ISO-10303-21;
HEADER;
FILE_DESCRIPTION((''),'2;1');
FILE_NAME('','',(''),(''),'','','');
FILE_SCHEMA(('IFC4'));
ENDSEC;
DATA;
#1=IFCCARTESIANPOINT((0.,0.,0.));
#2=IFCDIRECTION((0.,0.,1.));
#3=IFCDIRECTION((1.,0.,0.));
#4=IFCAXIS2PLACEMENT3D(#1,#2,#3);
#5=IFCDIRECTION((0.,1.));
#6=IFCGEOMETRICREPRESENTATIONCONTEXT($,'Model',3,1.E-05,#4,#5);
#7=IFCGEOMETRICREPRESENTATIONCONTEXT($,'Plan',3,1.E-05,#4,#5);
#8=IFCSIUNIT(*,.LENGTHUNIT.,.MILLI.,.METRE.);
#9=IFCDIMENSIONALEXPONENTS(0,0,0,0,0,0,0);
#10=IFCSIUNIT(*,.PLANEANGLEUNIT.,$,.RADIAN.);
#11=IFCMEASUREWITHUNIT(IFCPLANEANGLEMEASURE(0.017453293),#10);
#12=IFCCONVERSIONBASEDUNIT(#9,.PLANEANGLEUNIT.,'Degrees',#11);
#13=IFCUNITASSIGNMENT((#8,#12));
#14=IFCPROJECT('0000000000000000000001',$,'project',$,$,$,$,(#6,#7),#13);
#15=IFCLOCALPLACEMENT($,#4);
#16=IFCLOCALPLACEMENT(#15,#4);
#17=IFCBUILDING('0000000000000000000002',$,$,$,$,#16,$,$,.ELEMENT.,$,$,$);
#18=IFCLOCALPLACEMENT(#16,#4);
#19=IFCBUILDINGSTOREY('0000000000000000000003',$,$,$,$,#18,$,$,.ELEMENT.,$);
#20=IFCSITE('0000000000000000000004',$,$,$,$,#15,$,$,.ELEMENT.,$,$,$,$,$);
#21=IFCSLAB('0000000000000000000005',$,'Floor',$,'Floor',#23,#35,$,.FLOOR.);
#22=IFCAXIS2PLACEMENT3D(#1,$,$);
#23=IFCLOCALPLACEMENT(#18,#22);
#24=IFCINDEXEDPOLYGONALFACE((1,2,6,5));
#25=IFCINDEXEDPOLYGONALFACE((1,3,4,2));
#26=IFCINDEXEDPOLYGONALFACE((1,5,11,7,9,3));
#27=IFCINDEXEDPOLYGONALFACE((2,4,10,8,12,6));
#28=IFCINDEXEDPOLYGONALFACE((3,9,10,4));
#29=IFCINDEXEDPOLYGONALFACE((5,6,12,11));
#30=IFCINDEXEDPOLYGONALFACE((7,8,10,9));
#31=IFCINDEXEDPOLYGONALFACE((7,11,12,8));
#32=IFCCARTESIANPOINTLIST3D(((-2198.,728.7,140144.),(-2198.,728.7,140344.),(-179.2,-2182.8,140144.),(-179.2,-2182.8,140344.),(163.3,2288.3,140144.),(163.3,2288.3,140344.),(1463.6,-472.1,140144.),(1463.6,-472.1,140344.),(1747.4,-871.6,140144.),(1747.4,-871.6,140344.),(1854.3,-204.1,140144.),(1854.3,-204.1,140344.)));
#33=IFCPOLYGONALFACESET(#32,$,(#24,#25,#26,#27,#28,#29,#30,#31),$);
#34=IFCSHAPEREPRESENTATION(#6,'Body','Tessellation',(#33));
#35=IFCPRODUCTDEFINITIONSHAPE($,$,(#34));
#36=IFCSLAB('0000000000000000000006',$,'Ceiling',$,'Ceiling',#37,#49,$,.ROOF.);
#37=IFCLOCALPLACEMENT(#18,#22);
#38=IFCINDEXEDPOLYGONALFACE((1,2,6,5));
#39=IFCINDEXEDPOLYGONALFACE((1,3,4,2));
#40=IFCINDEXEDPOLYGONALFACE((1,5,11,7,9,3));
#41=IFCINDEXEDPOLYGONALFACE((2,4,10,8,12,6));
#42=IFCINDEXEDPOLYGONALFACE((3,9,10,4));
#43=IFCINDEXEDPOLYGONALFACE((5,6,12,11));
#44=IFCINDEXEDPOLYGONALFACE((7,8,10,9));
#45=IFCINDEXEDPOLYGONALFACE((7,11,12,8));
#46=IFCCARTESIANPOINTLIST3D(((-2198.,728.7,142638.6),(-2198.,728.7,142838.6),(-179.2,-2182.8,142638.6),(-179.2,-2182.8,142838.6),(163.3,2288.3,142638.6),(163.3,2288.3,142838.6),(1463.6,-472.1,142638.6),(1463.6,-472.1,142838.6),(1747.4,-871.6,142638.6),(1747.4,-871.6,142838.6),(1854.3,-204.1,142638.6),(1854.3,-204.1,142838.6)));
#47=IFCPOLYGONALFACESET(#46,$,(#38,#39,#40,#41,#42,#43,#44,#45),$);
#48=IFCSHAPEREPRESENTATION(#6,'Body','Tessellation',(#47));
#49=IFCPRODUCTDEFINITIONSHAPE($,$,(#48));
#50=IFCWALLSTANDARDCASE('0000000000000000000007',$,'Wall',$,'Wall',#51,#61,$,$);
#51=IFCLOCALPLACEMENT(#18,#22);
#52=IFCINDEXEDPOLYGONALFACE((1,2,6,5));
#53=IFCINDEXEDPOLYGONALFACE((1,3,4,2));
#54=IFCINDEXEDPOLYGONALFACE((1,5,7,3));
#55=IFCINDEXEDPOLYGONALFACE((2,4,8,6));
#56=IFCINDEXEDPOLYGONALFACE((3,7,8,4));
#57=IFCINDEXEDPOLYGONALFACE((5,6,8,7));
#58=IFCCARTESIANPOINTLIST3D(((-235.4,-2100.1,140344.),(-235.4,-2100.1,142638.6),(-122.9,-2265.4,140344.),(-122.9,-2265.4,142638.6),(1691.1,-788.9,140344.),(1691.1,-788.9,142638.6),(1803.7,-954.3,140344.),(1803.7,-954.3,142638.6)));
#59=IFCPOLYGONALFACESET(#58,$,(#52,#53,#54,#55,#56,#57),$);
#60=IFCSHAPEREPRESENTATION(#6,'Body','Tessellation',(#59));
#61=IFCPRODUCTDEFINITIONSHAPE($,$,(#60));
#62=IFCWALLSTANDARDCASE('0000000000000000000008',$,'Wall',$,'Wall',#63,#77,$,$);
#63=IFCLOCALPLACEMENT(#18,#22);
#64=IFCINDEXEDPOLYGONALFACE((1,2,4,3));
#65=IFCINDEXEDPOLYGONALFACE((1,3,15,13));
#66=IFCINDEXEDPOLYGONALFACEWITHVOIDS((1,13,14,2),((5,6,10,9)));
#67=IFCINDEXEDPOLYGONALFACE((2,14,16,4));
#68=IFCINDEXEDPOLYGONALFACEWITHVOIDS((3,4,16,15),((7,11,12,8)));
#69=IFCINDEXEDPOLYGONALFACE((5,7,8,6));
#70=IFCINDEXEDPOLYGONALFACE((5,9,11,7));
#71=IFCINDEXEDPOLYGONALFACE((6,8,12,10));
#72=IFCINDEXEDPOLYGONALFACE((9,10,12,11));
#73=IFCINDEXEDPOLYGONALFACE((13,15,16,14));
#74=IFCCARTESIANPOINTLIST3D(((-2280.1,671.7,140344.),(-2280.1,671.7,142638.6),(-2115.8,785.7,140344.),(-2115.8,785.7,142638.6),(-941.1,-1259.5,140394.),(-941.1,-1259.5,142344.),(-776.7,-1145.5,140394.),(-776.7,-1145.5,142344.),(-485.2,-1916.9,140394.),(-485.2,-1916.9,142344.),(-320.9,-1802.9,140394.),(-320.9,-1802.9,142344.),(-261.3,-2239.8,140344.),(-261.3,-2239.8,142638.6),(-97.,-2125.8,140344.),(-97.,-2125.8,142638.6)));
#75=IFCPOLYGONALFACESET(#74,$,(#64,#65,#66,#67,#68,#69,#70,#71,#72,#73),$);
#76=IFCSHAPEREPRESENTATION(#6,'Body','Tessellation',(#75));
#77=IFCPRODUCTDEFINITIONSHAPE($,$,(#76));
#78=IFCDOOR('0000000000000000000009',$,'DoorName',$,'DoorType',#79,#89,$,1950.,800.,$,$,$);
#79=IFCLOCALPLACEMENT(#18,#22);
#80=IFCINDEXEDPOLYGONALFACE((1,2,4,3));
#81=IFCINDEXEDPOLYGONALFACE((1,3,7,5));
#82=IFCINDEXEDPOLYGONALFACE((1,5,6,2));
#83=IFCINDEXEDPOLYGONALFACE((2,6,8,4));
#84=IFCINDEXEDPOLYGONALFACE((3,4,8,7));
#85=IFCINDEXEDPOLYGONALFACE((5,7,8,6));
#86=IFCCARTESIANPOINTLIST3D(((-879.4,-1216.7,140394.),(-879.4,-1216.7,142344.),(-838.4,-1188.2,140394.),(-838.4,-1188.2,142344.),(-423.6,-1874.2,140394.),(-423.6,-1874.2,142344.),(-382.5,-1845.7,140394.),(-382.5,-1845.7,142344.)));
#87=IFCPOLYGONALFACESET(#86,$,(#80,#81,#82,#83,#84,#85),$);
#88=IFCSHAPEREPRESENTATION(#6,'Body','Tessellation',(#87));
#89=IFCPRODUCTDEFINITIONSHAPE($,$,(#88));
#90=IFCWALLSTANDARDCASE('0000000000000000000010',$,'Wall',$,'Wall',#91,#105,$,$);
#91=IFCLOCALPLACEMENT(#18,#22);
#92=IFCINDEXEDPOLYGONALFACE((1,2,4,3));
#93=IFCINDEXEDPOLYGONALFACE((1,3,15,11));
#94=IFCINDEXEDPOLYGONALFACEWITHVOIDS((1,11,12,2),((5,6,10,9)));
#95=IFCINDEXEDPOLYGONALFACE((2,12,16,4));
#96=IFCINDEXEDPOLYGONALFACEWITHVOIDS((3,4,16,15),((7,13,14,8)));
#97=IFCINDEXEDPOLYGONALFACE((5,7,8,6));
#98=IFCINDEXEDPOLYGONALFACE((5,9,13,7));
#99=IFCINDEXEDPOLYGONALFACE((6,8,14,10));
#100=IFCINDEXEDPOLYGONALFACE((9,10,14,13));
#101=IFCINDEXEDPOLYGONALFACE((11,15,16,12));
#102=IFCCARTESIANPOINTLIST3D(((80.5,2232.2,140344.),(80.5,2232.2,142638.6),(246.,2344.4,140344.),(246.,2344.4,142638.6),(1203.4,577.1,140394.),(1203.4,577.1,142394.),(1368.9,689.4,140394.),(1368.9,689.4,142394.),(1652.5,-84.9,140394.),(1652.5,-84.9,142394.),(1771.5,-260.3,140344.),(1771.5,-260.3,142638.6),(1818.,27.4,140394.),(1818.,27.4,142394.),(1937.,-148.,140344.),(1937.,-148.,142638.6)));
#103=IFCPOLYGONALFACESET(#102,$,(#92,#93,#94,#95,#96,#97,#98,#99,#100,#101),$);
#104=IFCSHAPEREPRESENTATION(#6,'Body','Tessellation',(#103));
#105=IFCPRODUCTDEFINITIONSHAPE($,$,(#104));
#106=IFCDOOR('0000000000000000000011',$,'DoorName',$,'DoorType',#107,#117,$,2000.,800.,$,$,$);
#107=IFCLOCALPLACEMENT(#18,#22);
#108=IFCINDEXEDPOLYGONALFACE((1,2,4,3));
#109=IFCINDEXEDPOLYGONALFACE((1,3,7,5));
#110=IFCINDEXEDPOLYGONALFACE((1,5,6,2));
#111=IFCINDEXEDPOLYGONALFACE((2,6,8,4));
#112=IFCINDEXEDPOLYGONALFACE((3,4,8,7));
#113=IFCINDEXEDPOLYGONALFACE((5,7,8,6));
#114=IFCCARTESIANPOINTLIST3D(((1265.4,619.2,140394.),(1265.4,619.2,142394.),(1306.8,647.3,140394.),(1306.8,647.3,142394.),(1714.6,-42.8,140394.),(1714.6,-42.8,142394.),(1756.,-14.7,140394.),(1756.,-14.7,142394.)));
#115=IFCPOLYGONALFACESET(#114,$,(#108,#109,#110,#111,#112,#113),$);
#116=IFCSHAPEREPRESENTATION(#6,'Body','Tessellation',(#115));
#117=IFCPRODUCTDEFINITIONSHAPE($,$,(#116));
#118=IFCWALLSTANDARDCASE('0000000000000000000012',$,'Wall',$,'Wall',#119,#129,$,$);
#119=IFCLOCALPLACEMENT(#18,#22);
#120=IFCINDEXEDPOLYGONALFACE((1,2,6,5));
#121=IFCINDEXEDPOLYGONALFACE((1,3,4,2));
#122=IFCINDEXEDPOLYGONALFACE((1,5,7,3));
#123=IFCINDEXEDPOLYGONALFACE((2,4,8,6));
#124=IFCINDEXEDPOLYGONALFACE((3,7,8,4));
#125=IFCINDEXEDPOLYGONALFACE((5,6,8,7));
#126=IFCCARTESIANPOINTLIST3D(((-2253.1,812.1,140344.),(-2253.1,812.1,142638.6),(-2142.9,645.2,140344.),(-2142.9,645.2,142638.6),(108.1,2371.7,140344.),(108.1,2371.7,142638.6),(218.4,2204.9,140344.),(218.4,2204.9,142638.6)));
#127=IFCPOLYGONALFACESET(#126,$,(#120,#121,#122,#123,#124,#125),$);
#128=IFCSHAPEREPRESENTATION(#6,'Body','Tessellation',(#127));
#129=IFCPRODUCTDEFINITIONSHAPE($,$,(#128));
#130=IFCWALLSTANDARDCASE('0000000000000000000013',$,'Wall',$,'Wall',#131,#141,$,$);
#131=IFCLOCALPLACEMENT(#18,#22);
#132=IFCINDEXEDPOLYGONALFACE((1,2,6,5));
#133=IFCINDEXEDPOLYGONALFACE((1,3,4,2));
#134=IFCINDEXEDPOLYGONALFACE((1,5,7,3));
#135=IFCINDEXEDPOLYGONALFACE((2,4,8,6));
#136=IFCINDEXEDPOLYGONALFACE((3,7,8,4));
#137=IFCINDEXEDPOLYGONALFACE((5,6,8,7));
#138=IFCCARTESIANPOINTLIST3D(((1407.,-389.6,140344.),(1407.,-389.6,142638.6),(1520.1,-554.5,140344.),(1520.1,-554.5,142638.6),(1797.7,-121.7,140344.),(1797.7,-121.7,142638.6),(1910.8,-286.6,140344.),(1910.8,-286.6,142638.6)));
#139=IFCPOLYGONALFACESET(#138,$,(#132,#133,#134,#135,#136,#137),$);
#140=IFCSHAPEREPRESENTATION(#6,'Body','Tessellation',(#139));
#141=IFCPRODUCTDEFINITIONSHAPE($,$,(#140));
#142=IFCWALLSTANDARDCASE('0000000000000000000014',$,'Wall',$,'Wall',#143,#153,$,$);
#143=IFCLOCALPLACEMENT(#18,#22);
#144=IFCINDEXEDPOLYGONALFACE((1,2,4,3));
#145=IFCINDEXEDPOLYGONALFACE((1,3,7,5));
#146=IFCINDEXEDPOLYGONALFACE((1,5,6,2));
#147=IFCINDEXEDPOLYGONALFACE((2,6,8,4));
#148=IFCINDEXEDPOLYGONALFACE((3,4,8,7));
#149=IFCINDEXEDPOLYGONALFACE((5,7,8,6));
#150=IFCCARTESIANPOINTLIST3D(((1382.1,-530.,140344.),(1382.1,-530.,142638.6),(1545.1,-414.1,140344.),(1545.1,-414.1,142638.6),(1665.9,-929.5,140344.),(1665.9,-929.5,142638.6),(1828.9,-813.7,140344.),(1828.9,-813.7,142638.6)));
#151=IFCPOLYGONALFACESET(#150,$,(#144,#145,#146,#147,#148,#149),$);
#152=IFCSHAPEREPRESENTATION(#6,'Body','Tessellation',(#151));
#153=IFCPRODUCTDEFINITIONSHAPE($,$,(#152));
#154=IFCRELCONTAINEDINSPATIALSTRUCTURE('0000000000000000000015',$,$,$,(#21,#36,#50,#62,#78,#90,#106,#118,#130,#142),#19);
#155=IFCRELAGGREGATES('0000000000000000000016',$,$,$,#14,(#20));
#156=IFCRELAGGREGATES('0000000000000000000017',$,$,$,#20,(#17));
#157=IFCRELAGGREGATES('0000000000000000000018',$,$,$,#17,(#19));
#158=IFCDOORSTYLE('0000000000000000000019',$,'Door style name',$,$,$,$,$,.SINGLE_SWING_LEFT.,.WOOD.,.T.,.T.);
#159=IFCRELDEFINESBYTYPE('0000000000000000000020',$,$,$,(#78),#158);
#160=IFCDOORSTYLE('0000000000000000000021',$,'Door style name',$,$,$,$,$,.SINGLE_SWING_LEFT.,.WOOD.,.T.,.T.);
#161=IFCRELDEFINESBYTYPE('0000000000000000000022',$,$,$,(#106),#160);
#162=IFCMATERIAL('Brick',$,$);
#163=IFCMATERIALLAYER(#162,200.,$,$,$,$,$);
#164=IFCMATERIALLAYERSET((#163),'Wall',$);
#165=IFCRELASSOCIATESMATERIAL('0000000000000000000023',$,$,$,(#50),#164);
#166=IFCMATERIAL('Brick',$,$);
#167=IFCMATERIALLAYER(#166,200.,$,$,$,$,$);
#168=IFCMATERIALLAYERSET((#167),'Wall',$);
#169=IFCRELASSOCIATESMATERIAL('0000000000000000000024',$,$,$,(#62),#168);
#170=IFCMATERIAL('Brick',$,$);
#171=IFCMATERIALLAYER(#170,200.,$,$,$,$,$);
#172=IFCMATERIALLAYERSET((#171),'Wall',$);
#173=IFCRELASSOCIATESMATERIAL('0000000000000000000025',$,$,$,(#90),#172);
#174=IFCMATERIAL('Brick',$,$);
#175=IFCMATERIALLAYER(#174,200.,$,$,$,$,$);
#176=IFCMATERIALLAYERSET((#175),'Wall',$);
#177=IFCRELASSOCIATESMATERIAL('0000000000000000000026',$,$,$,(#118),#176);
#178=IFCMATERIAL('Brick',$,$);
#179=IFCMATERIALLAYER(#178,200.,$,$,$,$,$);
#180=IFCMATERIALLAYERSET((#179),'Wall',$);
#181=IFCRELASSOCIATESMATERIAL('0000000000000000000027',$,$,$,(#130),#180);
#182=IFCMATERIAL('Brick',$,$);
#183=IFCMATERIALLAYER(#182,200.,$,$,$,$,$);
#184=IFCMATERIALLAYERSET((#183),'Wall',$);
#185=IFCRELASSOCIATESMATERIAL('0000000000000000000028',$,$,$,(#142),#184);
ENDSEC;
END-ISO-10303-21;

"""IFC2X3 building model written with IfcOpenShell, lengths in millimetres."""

from ifc_helpers import new_model, entity, si_unit, converted_unit, direction, frame, origin_with_axes, place, context, project, spatial, polyline, outline, extrude, material, layer, layer_set, layer_usage, type_object, element, fill, save


model = new_model("IFC2X3")

# Units and contexts
model_context = context("Model", 3, precision=1e-05, world=origin_with_axes(), true_north=direction((0.0, 1.0)))
plan_context = context("Plan", 3, precision=1e-05, world=origin_with_axes(), true_north=direction((0.0, 1.0)))
ifc_project = project(units=[si_unit("LENGTHUNIT", "METRE", prefix="MILLI"), converted_unit("PLANEANGLEUNIT", "Degrees", entity("IfcPlaneAngleMeasure", 0.017453293), si_unit("PLANEANGLEUNIT", "RADIAN"), dimensions=[0, 0, 0, 0, 0, 0, 0])], contexts=[model_context, plan_context])

# Site, building, storey
site_placement = place(None, origin_with_axes())
site = spatial("IfcSite", under=ifc_project, at=site_placement, CompositionType="ELEMENT")
building_placement = place(site_placement, origin_with_axes())
building = spatial("IfcBuilding", under=site, at=building_placement, CompositionType="ELEMENT")
storey_placement = place(building_placement, origin_with_axes())
storey = spatial("IfcBuildingStorey", under=building, at=storey_placement, CompositionType="ELEMENT")

# Slabs
slab_1_placement = place(storey_placement, frame((0.0, 0.0, 140144.0), z_axis=(0.0, 0.0, 1.0), x_axis=(1.0, 0.0, 0.0)))
element("IfcSlab", 1, at=slab_1_placement, inside=storey, Name="Floor", ObjectType="Floor", PredefinedType="FLOOR", context=model_context, shape_type="SweptSolid", body=[
    extrude(outline(polyline([(1747.4, -871.6), (1463.6, -472.1), (1854.3, -204.1), (163.3, 2288.3), (-2198.0, 728.7), (-179.2, -2182.8), (1747.4, -871.6)])), origin_with_axes(), (0.0, 0.0, 1.0), 200.0),
])
slab_2_placement = place(storey_placement, frame((0.0, 0.0, 142638.6), z_axis=(0.0, 0.0, 1.0), x_axis=(1.0, 0.0, 0.0)))
element("IfcSlab", 2, at=slab_2_placement, inside=storey, Name="Ceiling", ObjectType="Ceiling", PredefinedType="ROOF", context=model_context, shape_type="SweptSolid", body=[
    extrude(outline(polyline([(1747.4, -871.6), (1463.6, -472.1), (1854.3, -204.1), (163.3, 2288.3), (-2198.0, 728.7), (-179.2, -2182.8), (1747.4, -871.6)])), origin_with_axes(), (0.0, 0.0, 1.0), 200.0),
])

# Wall
ifc_material_1 = material(Name="Brick")
ifc_layer_1 = layer(ifc_material_1, 200.0)
ifc_layer_set_1 = layer_set([ifc_layer_1], Name="Wall")
ifc_layer_usage_1 = layer_usage(ifc_layer_set_1, "AXIS2", "POSITIVE", -100.0)
wall_1_placement = place(storey_placement, frame((784.1, -1527.2, 140344.0), z_axis=(0.0, 0.0, 1.0), x_axis=(-0.826702, -0.56264, 0.0)))
element("IfcWallStandardCase", 3, at=wall_1_placement, inside=storey, material=ifc_layer_usage_1, Name="Wall", ObjectType="Wall", context=model_context, shape_type="SweptSolid", body=[
    extrude(outline(polyline([(-1165.2, -100.0), (1165.2, -100.0), (1165.2, 100.0), (-1165.2, 100.0), (-1165.2, -100.0)])), origin_with_axes(), (0.0, 0.0, 1.0), 2294.6),
])

# Walls, openings, doors
ifc_material_2 = material(Name="Brick")
ifc_layer_2 = layer(ifc_material_2, 200.0)
ifc_layer_set_2 = layer_set([ifc_layer_2], Name="Wall")
ifc_layer_usage_2 = layer_usage(ifc_layer_set_2, "AXIS2", "POSITIVE", -100.0)
wall_2_placement = place(storey_placement, frame((-1188.6, -727.1, 140344.0), z_axis=(0.0, 0.0, 1.0), x_axis=(0.569816, -0.821772, 0.0)))
wall_2 = element("IfcWallStandardCase", 4, at=wall_2_placement, inside=storey, material=ifc_layer_usage_2, Name="Wall", ObjectType="Wall", context=model_context, shape_type="SweptSolid", body=[
    extrude(outline(polyline([(-1771.4, -100.0), (1771.4, -100.0), (1771.4, 100.0), (-1771.4, 100.0), (-1771.4, -100.0)])), origin_with_axes(), (0.0, 0.0, 1.0), 2294.6),
])
placement_1 = place(storey_placement, frame((-631.0, -1531.2, 140394.0), z_axis=(0.0, 0.0, 1.0), x_axis=(0.569816, -0.821772, 0.0)))
opening_1 = element("IfcOpeningElement", 5, at=placement_1, cuts=wall_2, ObjectType="OpeningElement", context=model_context, shape_type="SweptSolid", body=[
    extrude(outline(polyline([(-400.0, -125.0), (400.0, -125.0), (400.0, 125.0), (-400.0, 125.0), (-400.0, -125.0)])), origin_with_axes(), (0.0, 0.0, 1.0), 1950.0),
])
door_style_1 = type_object("IfcDoorStyle", Name="Door style name", ConstructionType="WOOD", OperationType="SINGLE_SWING_LEFT", ParameterTakesPrecedence=True, Sizeable=True)
door_1 = element("IfcDoor", 6, at=placement_1, inside=storey, type_object=door_style_1, Name="DoorName", ObjectType="DoorType", OverallHeight=1950.0, OverallWidth=800.0, context=model_context, shape_type="SweptSolid", body=[
    extrude(outline(polyline([(-400.0, -25.0), (400.0, -25.0), (400.0, 25.0), (-400.0, 25.0), (-400.0, -25.0)])), origin_with_axes(), (0.0, 0.0, 1.0), 1950.0),
])
fill(opening_1, door_1)
ifc_material_3 = material(Name="Brick")
ifc_layer_3 = layer(ifc_material_3, 200.0)
ifc_layer_set_3 = layer_set([ifc_layer_3], Name="Wall")
ifc_layer_usage_3 = layer_usage(ifc_layer_set_3, "AXIS2", "POSITIVE", -100.0)
wall_3_placement = place(storey_placement, frame((1008.8, 1042.1, 140344.0), z_axis=(0.0, 0.0, 1.0), x_axis=(0.561438, -0.827519, 0.0)))
wall_3 = element("IfcWallStandardCase", 7, at=wall_3_placement, inside=storey, material=ifc_layer_usage_3, Name="Wall", ObjectType="Wall", context=model_context, shape_type="SweptSolid", body=[
    extrude(outline(polyline([(-1506.0, -100.0), (1506.0, -100.0), (1506.0, 100.0), (-1506.0, 100.0), (-1506.0, -100.0)])), origin_with_axes(), (0.0, 0.0, 1.0), 2294.6),
])
placement_2 = place(storey_placement, frame((1510.7, 302.3, 140394.0), z_axis=(0.0, 0.0, 1.0), x_axis=(0.561438, -0.827519, 0.0)))
opening_2 = element("IfcOpeningElement", 8, at=placement_2, cuts=wall_3, ObjectType="OpeningElement", context=model_context, shape_type="SweptSolid", body=[
    extrude(outline(polyline([(-400.0, -125.0), (400.0, -125.0), (400.0, 125.0), (-400.0, 125.0), (-400.0, -125.0)])), origin_with_axes(), (0.0, 0.0, 1.0), 2000.0),
])
door_style_2 = type_object("IfcDoorStyle", Name="Door style name", ConstructionType="WOOD", OperationType="SINGLE_SWING_LEFT", ParameterTakesPrecedence=True, Sizeable=True)
door_2 = element("IfcDoor", 9, at=placement_2, inside=storey, type_object=door_style_2, Name="DoorName", ObjectType="DoorType", OverallHeight=2000.0, OverallWidth=800.0, context=model_context, shape_type="SweptSolid", body=[
    extrude(outline(polyline([(-400.0, -25.0), (400.0, -25.0), (400.0, 25.0), (-400.0, 25.0), (-400.0, -25.0)])), origin_with_axes(), (0.0, 0.0, 1.0), 2000.0),
])
fill(opening_2, door_2)

# Walls
ifc_material_4 = material(Name="Brick")
ifc_layer_4 = layer(ifc_material_4, 200.0)
ifc_layer_set_4 = layer_set([ifc_layer_4], Name="Wall")
ifc_layer_usage_4 = layer_usage(ifc_layer_set_4, "AXIS2", "POSITIVE", -100.0)
wall_4_placement = place(storey_placement, frame((-1017.4, 1508.5, 140344.0), z_axis=(0.0, 0.0, 1.0), x_axis=(-0.834412, -0.551142, 0.0)))
element("IfcWallStandardCase", 10, at=wall_4_placement, inside=storey, material=ifc_layer_usage_4, Name="Wall", ObjectType="Wall", context=model_context, shape_type="SweptSolid", body=[
    extrude(outline(polyline([(-1414.9, -100.0), (1414.9, -100.0), (1414.9, 100.0), (-1414.9, 100.0), (-1414.9, -100.0)])), origin_with_axes(), (0.0, 0.0, 1.0), 2294.6),
])
ifc_material_5 = material(Name="Brick")
ifc_layer_5 = layer(ifc_material_5, 200.0)
ifc_layer_set_5 = layer_set([ifc_layer_5], Name="Wall")
ifc_layer_usage_5 = layer_usage(ifc_layer_set_5, "AXIS2", "POSITIVE", -100.0)
wall_5_placement = place(storey_placement, frame((1658.9, -338.1, 140344.0), z_axis=(0.0, 0.0, 1.0), x_axis=(-0.824689, -0.565587, 0.0)))
element("IfcWallStandardCase", 11, at=wall_5_placement, inside=storey, material=ifc_layer_usage_5, Name="Wall", ObjectType="Wall", context=model_context, shape_type="SweptSolid", body=[
    extrude(outline(polyline([(-236.9, -100.0), (236.9, -100.0), (236.9, 100.0), (-236.9, 100.0), (-236.9, -100.0)])), origin_with_axes(), (0.0, 0.0, 1.0), 2294.6),
])
ifc_material_6 = material(Name="Brick")
ifc_layer_6 = layer(ifc_material_6, 200.0)
ifc_layer_set_6 = layer_set([ifc_layer_6], Name="Wall")
ifc_layer_usage_6 = layer_usage(ifc_layer_set_6, "AXIS2", "POSITIVE", -100.0)
wall_6_placement = place(storey_placement, frame((1605.5, -671.8, 140344.0), z_axis=(0.0, 0.0, 1.0), x_axis=(0.5791, -0.815256, 0.0)))
element("IfcWallStandardCase", 12, at=wall_6_placement, inside=storey, material=ifc_layer_usage_6, Name="Wall", ObjectType="Wall", context=model_context, shape_type="SweptSolid", body=[
    extrude(outline(polyline([(-245.0, -100.0), (245.0, -100.0), (245.0, 100.0), (-245.0, 100.0), (-245.0, -100.0)])), origin_with_axes(), (0.0, 0.0, 1.0), 2294.6),
])

save(model, "model.ifc")
